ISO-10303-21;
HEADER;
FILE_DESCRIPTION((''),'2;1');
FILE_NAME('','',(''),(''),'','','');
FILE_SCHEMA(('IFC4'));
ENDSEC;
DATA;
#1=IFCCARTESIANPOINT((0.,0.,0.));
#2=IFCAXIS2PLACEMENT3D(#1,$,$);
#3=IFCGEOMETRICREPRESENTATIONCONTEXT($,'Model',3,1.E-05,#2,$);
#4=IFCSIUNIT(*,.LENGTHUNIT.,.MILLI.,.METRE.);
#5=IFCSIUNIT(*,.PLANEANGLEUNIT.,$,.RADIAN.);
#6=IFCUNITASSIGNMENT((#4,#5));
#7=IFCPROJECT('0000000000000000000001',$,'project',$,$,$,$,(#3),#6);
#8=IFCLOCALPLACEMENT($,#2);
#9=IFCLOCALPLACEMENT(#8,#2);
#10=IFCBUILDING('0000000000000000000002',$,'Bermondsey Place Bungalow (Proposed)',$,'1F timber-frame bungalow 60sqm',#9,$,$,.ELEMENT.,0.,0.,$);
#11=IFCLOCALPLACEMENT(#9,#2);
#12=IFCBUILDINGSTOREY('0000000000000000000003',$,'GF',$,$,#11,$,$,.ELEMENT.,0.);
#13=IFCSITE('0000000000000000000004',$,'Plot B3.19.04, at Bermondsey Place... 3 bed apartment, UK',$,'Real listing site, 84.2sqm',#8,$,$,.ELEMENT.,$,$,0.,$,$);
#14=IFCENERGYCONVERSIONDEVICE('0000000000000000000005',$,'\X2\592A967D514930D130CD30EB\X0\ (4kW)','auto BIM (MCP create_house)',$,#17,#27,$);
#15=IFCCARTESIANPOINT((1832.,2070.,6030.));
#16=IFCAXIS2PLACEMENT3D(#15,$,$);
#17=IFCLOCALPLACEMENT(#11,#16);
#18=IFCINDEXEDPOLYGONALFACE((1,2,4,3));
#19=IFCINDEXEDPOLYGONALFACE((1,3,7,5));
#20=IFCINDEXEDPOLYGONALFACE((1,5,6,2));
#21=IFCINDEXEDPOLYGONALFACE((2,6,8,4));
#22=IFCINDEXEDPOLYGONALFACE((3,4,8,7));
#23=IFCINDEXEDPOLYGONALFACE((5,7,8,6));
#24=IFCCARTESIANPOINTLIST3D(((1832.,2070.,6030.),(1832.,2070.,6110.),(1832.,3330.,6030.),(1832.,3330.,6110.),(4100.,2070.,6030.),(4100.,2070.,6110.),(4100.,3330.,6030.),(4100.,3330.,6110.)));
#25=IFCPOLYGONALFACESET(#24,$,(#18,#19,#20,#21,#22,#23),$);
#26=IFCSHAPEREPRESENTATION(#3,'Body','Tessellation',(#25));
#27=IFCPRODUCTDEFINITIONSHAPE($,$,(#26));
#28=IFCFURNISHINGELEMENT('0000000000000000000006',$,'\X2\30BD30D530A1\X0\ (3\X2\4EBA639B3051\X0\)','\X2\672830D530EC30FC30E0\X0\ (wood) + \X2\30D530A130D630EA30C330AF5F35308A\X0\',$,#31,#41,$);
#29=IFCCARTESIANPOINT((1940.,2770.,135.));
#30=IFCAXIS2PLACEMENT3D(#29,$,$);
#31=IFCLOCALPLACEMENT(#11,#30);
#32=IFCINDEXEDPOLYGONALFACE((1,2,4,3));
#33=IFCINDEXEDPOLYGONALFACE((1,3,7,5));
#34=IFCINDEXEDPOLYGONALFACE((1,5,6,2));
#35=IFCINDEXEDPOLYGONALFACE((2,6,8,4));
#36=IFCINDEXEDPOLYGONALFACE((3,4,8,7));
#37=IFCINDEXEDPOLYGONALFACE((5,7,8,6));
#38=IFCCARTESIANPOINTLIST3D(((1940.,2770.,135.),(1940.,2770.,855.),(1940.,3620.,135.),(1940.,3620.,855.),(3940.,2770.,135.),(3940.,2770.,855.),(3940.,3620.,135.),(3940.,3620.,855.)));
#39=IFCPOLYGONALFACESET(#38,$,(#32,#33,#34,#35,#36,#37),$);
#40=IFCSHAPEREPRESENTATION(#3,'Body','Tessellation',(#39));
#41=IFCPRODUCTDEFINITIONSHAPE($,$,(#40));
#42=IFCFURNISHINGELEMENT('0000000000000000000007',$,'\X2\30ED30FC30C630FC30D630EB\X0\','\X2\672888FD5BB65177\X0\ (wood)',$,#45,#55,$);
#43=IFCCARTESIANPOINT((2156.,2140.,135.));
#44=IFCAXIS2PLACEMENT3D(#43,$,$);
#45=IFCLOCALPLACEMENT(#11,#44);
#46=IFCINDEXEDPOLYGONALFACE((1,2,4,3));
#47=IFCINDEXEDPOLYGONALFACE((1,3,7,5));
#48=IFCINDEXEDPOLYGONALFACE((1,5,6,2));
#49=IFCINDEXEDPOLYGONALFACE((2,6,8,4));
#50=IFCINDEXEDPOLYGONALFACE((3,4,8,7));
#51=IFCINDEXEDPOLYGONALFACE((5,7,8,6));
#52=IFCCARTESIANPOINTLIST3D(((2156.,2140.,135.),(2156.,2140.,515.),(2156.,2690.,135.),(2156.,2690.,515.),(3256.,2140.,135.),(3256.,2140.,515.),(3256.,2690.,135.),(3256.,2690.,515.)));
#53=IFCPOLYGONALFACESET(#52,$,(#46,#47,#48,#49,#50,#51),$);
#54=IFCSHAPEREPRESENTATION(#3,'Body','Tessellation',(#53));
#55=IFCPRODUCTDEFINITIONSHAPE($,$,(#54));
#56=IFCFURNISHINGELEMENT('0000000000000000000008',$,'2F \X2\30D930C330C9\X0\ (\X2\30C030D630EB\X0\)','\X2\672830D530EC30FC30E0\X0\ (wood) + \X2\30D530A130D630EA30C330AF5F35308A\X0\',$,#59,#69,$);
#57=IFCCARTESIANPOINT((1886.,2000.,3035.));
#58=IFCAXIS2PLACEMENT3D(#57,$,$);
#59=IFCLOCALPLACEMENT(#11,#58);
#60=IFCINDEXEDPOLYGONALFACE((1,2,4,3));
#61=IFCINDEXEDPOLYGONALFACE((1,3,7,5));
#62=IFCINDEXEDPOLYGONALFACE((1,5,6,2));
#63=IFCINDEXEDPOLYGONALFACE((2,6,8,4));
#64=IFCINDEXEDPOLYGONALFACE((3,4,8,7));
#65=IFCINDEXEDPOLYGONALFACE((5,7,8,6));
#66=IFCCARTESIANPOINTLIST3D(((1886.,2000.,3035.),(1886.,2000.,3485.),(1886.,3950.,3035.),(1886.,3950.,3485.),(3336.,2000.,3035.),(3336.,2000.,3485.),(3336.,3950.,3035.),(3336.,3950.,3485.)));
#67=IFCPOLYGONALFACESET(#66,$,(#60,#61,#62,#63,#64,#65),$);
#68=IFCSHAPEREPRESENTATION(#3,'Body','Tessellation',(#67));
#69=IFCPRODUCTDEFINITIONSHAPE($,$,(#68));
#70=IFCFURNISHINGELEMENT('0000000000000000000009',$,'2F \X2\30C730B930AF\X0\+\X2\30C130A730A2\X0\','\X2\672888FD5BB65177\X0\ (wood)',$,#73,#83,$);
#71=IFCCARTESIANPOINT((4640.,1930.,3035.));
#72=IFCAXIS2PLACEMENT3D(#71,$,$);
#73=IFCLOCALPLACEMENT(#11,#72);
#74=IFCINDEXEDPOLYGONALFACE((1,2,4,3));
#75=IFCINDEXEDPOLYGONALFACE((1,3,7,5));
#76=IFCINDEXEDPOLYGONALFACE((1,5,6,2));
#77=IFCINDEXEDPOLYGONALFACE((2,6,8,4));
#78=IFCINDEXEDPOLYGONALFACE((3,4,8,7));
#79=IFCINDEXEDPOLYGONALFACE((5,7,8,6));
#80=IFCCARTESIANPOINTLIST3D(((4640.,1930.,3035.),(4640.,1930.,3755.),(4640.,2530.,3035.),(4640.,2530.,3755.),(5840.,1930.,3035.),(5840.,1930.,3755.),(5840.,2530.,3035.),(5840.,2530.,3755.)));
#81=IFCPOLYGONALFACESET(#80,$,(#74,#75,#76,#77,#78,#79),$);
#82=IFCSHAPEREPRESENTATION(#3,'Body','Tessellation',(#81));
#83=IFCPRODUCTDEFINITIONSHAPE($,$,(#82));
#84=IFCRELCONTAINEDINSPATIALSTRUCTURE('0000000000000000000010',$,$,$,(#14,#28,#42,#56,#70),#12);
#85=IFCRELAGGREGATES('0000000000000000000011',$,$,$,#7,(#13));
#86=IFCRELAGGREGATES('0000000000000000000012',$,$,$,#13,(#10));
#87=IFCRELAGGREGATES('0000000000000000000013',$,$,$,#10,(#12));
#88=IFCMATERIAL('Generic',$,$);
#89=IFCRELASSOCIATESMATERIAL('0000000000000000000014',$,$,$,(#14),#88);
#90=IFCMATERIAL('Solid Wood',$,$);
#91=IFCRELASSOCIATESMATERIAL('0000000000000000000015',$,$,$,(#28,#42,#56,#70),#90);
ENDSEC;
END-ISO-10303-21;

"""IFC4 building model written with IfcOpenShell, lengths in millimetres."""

from ifc_helpers import new_model, si_unit, frame, frame_2d, origin, place, context, project, spatial, rectangle, extrude, material, element, save


model = new_model("IFC4")

# Units and contexts
model_context = context("Model", 3, precision=1e-05, world=origin())
ifc_project = project(units=[si_unit("LENGTHUNIT", "METRE", prefix="MILLI"), si_unit("PLANEANGLEUNIT", "RADIAN")], contexts=[model_context])

# Site, building, storey
site_placement = place(None, origin())
site = spatial("IfcSite", under=ifc_project, at=site_placement, Name="Plot B3.19.04, at Bermondsey Place... 3 bed apartment, UK", ObjectType="Real listing site, 84.2sqm", CompositionType="ELEMENT", RefElevation=0.0)
building_placement = place(site_placement, origin())
building = spatial("IfcBuilding", under=site, at=building_placement, Name="Bermondsey Place Bungalow (Proposed)", ObjectType="1F timber-frame bungalow 60sqm", CompositionType="ELEMENT", ElevationOfRefHeight=0.0, ElevationOfTerrain=0.0)
storey_placement = place(building_placement, origin())
storey = spatial("IfcBuildingStorey", under=building, at=storey_placement, Name="GF", CompositionType="ELEMENT", Elevation=0.0)

# Shared definitions
ifc_material_1 = material(Name="Solid Wood")

# Shared definitions
ifc_material_2 = material(Name="Generic")

# Energy conversion device
energy_conversion_device_placement = place(storey_placement, frame((1832.0, 2070.0, 6030.0)))
element("IfcEnergyConversionDevice", 1, at=energy_conversion_device_placement, inside=storey, material=ifc_material_2, Name="太陽光パネル (4kW)", Description="auto BIM (MCP create_house)", context=model_context, shape_type="SweptSolid", body=[
    extrude(rectangle(XDim=2268.0, YDim=1260.0, at=frame_2d((1134.0, 630.0))), frame((1832.0, 2070.0, 6030.0)), (0.0, 0.0, 1.0), 80.0),
])

# Furnishing elements
furnishing_1_placement = place(storey_placement, frame((1940.0, 2770.0, 135.0)))
element("IfcFurnishingElement", 2, at=furnishing_1_placement, inside=storey, material=ifc_material_1, Name="ソファ (3人掛け)", Description="木フレーム (wood) + ファブリック張り", context=model_context, shape_type="SweptSolid", body=[
    extrude(rectangle(XDim=2000.0, YDim=850.0, at=frame_2d((1000.0, 425.0))), frame((1940.0, 2770.0, 135.0)), (0.0, 0.0, 1.0), 720.0),
])
furnishing_2_placement = place(storey_placement, frame((2156.0, 2140.0, 135.0)))
element("IfcFurnishingElement", 3, at=furnishing_2_placement, inside=storey, material=ifc_material_1, Name="ローテーブル", Description="木製家具 (wood)", context=model_context, shape_type="SweptSolid", body=[
    extrude(rectangle(XDim=1100.0, YDim=550.0, at=frame_2d((550.0, 275.0))), frame((2156.0, 2140.0, 135.0)), (0.0, 0.0, 1.0), 380.0),
])
furnishing_3_placement = place(storey_placement, frame((1886.0, 2000.0, 3035.0)))
element("IfcFurnishingElement", 4, at=furnishing_3_placement, inside=storey, material=ifc_material_1, Name="2F ベッド (ダブル)", Description="木フレーム (wood) + ファブリック張り", context=model_context, shape_type="SweptSolid", body=[
    extrude(rectangle(XDim=1450.0, YDim=1950.0, at=frame_2d((725.0, 975.0))), frame((1886.0, 2000.0, 3035.0)), (0.0, 0.0, 1.0), 450.0),
])
furnishing_4_placement = place(storey_placement, frame((4640.0, 1930.0, 3035.0)))
element("IfcFurnishingElement", 5, at=furnishing_4_placement, inside=storey, material=ifc_material_1, Name="2F デスク+チェア", Description="木製家具 (wood)", context=model_context, shape_type="SweptSolid", body=[
    extrude(rectangle(XDim=1200.0, YDim=600.0, at=frame_2d((600.0, 300.0))), frame((4640.0, 1930.0, 3035.0)), (0.0, 0.0, 1.0), 720.0),
])

save(model, "model.ifc")
